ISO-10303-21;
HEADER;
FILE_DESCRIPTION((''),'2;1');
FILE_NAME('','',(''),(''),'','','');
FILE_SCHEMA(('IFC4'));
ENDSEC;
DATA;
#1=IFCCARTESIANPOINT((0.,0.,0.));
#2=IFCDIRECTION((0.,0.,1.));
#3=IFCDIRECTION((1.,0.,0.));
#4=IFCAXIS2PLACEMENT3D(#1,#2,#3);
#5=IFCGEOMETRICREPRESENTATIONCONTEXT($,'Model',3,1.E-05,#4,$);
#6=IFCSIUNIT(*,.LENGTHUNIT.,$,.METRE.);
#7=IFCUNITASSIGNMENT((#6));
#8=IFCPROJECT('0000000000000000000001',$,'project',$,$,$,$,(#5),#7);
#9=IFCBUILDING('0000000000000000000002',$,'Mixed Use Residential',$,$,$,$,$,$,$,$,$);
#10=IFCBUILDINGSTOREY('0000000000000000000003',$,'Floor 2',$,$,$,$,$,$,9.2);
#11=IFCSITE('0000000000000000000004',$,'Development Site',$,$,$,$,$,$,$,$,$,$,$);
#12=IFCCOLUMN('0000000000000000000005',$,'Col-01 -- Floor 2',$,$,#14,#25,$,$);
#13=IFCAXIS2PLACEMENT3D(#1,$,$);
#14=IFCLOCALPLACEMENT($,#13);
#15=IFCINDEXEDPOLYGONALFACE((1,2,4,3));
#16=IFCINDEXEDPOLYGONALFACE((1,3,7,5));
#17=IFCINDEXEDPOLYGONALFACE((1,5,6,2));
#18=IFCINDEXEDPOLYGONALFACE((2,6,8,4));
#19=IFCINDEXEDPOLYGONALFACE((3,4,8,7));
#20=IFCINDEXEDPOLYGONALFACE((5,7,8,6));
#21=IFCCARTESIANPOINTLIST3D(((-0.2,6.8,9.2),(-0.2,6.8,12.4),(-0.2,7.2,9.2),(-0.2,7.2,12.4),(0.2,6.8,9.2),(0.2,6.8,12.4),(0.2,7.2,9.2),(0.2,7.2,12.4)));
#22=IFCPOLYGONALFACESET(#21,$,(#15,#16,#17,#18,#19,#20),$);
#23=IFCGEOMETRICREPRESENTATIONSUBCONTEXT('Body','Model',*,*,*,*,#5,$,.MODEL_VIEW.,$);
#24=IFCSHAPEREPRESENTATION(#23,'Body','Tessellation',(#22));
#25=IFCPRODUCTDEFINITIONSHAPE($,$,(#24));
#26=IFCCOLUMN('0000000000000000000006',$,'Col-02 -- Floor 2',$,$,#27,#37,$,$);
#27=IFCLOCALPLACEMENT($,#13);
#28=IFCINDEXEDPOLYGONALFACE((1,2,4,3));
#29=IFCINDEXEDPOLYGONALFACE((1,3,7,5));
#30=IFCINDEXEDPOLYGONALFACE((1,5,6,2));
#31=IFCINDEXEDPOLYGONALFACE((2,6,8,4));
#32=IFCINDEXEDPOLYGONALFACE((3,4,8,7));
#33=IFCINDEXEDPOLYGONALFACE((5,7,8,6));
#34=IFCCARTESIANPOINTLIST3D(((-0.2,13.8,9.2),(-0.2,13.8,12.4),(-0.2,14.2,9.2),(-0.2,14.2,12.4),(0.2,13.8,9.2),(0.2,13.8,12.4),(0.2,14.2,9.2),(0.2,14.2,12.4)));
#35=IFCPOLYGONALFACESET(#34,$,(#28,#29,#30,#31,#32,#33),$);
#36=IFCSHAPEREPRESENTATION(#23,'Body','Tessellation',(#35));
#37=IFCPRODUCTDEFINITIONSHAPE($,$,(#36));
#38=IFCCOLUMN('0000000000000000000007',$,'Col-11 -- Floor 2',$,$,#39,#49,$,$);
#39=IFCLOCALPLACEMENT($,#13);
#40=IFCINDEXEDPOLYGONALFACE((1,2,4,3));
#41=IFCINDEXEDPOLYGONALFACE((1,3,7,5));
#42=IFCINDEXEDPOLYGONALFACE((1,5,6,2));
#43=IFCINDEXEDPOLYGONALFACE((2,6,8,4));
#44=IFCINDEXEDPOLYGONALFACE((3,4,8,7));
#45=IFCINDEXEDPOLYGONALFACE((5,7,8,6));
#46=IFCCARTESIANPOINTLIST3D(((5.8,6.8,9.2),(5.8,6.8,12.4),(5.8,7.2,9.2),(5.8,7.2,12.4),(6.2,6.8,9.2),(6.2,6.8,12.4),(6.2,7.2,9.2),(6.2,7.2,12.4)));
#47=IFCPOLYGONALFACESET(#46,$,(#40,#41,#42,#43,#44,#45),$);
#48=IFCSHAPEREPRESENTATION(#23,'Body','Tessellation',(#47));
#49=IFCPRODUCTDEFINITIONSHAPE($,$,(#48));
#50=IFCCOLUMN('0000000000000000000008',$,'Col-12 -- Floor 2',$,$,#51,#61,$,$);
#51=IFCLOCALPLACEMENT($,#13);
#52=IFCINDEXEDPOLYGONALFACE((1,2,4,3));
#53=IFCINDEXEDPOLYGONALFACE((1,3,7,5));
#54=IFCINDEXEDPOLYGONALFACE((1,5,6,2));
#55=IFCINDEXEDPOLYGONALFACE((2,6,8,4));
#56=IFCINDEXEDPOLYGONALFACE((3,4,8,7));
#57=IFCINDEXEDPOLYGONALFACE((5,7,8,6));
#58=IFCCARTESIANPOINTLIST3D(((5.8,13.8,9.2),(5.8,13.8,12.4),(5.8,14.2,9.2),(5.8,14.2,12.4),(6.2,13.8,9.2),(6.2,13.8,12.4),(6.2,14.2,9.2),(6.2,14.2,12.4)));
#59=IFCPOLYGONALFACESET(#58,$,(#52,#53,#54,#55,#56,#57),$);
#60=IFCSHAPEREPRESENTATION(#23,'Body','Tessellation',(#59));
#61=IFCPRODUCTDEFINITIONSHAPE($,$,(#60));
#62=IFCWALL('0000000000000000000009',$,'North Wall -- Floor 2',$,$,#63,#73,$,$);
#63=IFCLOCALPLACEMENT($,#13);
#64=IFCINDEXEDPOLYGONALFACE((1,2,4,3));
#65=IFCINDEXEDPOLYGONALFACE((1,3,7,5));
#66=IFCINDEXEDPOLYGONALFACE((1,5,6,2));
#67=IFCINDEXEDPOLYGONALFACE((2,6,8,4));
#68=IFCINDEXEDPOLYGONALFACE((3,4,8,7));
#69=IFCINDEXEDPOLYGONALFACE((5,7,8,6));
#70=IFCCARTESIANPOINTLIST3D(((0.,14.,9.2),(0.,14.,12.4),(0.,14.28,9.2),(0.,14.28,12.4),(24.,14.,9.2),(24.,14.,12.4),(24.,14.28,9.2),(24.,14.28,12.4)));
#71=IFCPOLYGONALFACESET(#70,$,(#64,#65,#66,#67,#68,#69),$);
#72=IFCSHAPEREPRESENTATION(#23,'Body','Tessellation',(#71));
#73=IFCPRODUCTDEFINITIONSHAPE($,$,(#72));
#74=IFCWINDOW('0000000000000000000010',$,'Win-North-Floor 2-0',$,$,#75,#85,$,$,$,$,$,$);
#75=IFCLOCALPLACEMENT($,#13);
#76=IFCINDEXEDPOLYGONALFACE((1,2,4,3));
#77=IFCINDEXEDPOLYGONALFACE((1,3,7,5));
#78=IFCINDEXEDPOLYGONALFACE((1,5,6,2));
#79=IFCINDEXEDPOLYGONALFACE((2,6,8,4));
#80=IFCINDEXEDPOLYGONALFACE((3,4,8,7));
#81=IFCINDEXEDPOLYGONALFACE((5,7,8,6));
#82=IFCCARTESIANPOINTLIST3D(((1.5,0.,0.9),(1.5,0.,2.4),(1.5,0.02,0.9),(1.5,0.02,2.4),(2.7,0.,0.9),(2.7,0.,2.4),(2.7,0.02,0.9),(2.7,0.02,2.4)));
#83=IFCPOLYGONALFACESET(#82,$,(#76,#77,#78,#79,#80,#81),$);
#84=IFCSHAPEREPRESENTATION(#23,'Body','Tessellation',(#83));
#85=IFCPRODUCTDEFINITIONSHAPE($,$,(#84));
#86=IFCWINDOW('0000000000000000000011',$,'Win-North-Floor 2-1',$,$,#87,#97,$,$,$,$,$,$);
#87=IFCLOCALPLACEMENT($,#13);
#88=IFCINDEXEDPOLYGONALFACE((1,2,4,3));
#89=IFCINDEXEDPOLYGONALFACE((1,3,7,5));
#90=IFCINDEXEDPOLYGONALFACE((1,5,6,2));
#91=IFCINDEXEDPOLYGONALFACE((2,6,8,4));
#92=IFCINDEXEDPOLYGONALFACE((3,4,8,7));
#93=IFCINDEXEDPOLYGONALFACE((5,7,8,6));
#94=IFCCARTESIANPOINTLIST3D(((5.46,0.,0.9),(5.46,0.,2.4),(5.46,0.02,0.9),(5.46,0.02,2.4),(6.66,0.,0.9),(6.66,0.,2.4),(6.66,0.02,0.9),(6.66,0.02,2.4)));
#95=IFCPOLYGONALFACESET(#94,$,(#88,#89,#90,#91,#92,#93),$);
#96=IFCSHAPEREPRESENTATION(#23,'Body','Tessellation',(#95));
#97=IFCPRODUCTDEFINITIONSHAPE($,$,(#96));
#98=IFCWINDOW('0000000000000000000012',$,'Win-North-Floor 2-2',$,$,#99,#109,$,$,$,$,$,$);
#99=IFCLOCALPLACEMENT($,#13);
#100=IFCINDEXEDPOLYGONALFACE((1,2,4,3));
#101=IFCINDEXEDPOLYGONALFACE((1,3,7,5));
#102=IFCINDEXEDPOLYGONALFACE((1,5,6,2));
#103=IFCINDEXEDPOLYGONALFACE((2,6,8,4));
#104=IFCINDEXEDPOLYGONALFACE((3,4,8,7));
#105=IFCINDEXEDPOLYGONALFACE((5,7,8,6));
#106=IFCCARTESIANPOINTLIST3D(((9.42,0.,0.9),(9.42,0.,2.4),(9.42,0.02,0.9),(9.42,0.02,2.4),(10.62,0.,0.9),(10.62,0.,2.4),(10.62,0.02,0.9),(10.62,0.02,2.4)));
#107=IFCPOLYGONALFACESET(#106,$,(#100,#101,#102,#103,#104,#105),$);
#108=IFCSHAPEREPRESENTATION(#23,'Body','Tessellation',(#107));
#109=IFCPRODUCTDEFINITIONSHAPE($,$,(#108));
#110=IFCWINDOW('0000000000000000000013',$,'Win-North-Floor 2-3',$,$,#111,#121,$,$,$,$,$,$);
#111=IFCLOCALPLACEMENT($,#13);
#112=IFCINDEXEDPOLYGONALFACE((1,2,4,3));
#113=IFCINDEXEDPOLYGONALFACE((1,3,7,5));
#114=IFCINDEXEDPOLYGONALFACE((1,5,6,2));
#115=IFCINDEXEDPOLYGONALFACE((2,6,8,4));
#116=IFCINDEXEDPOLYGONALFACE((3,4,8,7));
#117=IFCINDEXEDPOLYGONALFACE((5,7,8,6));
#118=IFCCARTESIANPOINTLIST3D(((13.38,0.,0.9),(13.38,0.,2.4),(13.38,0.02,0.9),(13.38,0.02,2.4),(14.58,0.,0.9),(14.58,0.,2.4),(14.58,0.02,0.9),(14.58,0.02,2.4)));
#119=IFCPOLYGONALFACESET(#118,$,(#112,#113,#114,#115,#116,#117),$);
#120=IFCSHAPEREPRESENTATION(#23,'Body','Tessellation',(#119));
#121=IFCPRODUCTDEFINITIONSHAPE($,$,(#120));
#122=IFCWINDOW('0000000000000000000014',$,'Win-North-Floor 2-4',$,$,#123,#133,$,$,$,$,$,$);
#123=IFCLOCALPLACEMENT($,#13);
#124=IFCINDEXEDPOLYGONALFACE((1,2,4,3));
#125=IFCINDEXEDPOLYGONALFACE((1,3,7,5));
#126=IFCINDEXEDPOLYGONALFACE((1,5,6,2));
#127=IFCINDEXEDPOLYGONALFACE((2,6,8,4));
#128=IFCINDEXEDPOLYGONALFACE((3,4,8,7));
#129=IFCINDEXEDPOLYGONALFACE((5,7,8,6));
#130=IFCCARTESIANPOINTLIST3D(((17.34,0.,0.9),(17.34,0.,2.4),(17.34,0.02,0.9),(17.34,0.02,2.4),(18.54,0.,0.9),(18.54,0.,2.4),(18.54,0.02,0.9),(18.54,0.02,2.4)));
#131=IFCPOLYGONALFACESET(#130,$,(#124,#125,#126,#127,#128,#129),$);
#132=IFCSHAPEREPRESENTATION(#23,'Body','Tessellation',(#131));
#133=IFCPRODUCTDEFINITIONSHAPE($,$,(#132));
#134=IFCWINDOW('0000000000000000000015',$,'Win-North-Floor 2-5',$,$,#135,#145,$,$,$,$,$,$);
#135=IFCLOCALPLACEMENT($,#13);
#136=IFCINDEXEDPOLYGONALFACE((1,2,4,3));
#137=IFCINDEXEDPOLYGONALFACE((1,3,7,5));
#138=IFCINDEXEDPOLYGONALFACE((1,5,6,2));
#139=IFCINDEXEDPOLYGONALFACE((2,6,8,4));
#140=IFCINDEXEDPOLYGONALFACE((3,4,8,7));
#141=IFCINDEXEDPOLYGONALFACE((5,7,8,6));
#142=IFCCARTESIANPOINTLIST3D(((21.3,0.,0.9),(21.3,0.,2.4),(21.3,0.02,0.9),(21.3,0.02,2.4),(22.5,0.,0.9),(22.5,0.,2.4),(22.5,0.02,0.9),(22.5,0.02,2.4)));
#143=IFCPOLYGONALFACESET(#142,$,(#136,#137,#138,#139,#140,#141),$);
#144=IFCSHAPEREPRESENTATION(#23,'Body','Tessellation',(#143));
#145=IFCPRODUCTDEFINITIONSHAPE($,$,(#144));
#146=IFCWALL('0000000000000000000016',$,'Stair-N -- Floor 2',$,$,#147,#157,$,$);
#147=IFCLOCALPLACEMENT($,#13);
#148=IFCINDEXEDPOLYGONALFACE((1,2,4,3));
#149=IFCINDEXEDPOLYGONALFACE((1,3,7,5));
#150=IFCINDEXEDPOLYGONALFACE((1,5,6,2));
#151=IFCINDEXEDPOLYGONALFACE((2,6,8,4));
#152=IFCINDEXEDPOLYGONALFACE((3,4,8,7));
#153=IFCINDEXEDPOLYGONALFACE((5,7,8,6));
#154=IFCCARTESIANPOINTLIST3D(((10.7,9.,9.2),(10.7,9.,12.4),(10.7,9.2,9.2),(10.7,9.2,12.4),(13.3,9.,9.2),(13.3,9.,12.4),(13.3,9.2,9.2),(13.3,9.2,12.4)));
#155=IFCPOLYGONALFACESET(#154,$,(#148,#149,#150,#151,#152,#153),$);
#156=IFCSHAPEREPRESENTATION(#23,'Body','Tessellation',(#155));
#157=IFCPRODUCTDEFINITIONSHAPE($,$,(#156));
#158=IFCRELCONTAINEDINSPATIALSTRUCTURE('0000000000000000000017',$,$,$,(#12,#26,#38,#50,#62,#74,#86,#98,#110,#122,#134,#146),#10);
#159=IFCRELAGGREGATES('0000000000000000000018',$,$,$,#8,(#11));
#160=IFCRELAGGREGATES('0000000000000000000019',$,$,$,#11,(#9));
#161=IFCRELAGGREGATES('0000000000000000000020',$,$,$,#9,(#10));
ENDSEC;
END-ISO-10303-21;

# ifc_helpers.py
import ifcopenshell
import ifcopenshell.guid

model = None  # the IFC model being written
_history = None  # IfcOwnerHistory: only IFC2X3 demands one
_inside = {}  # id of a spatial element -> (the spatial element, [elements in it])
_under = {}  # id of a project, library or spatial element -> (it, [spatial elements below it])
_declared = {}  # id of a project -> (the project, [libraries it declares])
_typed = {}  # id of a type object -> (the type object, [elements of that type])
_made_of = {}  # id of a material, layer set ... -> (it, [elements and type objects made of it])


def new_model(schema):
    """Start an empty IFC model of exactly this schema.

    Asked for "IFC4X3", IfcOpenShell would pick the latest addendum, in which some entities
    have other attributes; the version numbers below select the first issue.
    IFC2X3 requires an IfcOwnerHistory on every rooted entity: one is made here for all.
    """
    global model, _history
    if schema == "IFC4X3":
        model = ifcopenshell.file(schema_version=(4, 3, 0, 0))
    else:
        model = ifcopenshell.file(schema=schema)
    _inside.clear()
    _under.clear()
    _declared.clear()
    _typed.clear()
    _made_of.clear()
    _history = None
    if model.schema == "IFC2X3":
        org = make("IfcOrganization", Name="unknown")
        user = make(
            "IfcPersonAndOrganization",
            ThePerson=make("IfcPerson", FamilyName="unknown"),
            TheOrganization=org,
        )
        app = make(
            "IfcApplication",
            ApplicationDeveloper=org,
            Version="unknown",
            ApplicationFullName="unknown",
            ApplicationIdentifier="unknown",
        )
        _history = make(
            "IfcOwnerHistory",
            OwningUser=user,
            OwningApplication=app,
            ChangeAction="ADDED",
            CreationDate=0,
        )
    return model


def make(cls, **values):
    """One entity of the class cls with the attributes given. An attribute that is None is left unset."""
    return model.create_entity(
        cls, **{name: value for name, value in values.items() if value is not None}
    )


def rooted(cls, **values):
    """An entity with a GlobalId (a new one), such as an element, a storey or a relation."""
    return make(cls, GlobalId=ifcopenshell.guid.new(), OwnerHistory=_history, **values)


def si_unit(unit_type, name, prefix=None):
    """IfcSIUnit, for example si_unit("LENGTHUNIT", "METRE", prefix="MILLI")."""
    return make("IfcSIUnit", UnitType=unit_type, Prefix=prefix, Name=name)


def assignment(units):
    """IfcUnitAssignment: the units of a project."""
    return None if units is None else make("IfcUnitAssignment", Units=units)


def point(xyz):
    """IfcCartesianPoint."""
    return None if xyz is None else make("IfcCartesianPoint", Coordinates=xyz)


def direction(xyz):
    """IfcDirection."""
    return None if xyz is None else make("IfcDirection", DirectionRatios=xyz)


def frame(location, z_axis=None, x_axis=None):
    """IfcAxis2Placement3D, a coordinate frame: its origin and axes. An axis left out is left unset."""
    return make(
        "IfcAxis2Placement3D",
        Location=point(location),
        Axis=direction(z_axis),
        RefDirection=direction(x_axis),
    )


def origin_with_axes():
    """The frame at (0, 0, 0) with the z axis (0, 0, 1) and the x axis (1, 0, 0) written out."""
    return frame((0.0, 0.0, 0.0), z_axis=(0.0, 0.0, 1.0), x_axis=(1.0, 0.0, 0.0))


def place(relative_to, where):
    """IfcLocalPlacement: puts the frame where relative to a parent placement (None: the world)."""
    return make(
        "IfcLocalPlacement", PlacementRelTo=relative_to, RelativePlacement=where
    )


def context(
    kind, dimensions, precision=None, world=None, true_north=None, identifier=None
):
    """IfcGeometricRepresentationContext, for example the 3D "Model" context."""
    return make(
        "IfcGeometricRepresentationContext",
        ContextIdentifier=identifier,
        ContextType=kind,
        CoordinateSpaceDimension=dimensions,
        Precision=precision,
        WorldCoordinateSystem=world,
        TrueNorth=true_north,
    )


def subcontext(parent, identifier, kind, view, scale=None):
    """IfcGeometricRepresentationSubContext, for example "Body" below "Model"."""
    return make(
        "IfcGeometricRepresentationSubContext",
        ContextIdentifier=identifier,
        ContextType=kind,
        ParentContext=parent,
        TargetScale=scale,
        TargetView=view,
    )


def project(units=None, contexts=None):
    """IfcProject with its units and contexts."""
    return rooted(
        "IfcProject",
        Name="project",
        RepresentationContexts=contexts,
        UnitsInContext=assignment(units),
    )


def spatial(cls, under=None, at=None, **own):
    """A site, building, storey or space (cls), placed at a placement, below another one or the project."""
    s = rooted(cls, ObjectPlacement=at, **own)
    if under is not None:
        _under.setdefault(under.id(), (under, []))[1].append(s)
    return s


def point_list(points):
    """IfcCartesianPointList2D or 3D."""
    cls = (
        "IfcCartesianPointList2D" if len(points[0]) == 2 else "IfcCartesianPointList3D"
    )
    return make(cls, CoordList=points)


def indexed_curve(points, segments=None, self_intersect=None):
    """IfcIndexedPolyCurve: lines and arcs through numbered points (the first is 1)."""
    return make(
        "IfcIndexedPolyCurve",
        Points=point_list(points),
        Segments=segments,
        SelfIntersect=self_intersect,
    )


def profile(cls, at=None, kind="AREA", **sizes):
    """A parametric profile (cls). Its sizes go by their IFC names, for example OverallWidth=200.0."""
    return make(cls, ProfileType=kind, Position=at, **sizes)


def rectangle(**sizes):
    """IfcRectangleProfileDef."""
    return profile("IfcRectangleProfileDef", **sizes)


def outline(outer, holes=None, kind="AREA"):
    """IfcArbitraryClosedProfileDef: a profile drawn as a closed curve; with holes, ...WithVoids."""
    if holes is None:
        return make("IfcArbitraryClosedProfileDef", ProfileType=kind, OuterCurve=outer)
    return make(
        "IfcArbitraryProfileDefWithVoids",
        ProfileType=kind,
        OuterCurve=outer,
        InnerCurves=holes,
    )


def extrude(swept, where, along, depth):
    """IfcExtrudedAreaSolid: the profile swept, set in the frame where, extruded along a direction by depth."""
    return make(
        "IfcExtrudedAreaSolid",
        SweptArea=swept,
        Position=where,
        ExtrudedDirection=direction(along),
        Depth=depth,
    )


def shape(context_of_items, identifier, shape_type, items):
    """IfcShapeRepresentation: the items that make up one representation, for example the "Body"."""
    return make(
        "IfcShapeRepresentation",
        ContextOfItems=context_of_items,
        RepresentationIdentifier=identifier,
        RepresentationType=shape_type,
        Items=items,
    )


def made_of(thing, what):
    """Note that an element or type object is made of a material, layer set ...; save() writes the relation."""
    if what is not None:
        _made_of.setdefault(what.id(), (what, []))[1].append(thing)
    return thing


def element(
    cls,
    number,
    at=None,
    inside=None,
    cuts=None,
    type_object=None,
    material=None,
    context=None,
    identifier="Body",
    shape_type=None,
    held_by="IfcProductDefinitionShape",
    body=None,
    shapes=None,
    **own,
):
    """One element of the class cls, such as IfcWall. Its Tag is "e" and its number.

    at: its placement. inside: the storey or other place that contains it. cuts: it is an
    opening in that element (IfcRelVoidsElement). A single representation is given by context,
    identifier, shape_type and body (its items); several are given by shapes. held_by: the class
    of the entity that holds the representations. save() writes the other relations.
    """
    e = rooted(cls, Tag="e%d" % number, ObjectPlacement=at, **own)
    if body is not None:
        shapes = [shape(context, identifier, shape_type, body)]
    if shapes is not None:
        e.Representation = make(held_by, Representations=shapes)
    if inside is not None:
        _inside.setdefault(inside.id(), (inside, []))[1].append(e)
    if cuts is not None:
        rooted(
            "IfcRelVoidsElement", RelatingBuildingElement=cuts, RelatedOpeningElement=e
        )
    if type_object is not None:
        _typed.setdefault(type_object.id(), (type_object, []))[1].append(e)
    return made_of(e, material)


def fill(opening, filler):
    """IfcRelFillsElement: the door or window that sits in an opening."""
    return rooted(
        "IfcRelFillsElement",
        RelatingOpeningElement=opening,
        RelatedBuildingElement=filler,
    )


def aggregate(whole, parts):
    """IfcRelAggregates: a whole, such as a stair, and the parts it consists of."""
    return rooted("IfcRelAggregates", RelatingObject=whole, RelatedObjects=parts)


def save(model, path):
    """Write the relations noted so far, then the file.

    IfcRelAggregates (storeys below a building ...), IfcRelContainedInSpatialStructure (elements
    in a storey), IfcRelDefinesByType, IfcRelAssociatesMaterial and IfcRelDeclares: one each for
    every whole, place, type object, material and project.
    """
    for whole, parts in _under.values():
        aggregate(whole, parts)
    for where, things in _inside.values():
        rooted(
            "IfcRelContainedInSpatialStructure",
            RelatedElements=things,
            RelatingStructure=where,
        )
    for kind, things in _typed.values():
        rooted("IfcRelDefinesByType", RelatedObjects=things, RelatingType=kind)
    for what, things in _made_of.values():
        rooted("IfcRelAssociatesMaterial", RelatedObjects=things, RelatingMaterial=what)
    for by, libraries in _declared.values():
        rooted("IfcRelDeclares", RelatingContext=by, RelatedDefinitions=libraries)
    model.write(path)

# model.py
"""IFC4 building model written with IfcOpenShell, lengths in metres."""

from ifc_helpers import new_model, si_unit, frame, origin_with_axes, place, context, subcontext, project, spatial, indexed_curve, rectangle, outline, extrude, element, fill, save


model = new_model("IFC4")

# Units and contexts
model_context = context("Model", 3, precision=1e-05, world=origin_with_axes())
body_context = subcontext(model_context, "Body", "Model", "MODEL_VIEW")
ifc_project = project(units=[si_unit("LENGTHUNIT", "METRE")], contexts=[model_context])

# Site, building, storey
site = spatial("IfcSite", under=ifc_project, Name="Development Site")
building = spatial("IfcBuilding", under=site, Name="Mixed Use Residential")
storey = spatial("IfcBuildingStorey", under=building, Name="Floor 2", Elevation=9.2)

# Columns
for number, where, z_axis, x_axis, name in (
    (1, (0.0, 7.0, 9.2), (0.0, 0.0, 1.0), (1.0, 0.0, 0.0), "Col-01 -- Floor 2"),
    (2, (0.0, 14.0, 9.2), (0.0, 0.0, 1.0), (1.0, 0.0, 0.0), "Col-02 -- Floor 2"),
    (3, (6.0, 7.0, 9.2), (0.0, 0.0, 1.0), (1.0, 0.0, 0.0), "Col-11 -- Floor 2"),
    (4, (6.0, 14.0, 9.2), (0.0, 0.0, 1.0), (1.0, 0.0, 0.0), "Col-12 -- Floor 2"),
):
    element("IfcColumn", number, at=place(None, frame(where, z_axis=z_axis, x_axis=x_axis)), inside=storey, Name=name, context=body_context, shape_type="SweptSolid", body=[
        extrude(rectangle(XDim=0.4, YDim=0.4), origin_with_axes(), (0.0, 0.0, 1.0), 3.2),
    ])

# Wall, openings, windows
wall_1_placement = place(None, frame((0.0, 14.0, 9.2), z_axis=(0.0, 0.0, 1.0), x_axis=(1.0, 0.0, 0.0)))
wall_1 = element("IfcWall", 5, at=wall_1_placement, inside=storey, Name="North Wall -- Floor 2", context=body_context, shape_type="SweptSolid", body=[
    extrude(outline(indexed_curve([(0.0, 0.0), (0.0, 0.28), (24.0, 0.28), (24.0, 0.0), (0.0, 0.0)], self_intersect=False)), origin_with_axes(), (0.0, 0.0, 1.0), 3.2),
])
opening_1_placement = place(wall_1_placement, frame((1.5, -14.0, -8.3), z_axis=(0.0, 0.0, 1.0), x_axis=(1.0, 0.0, 0.0)))
opening_1 = element("IfcOpeningElement", 6, at=opening_1_placement, cuts=wall_1, context=body_context, shape_type="SweptSolid", body=[
    extrude(outline(indexed_curve([(0.0, 0.0), (0.0, 0.28), (1.2, 0.28), (1.2, 0.0), (0.0, 0.0)], self_intersect=False)), origin_with_axes(), (0.0, 0.0, 1.0), 1.5),
])
opening_2_placement = place(wall_1_placement, frame((5.46, -14.0, -8.3), z_axis=(0.0, 0.0, 1.0), x_axis=(1.0, 0.0, 0.0)))
opening_2 = element("IfcOpeningElement", 7, at=opening_2_placement, cuts=wall_1, context=body_context, shape_type="SweptSolid", body=[
    extrude(outline(indexed_curve([(0.0, 0.0), (0.0, 0.28), (1.2, 0.28), (1.2, 0.0), (0.0, 0.0)], self_intersect=False)), origin_with_axes(), (0.0, 0.0, 1.0), 1.5),
])
opening_3_placement = place(wall_1_placement, frame((9.42, -14.0, -8.3), z_axis=(0.0, 0.0, 1.0), x_axis=(1.0, 0.0, 0.0)))
opening_3 = element("IfcOpeningElement", 8, at=opening_3_placement, cuts=wall_1, context=body_context, shape_type="SweptSolid", body=[
    extrude(outline(indexed_curve([(0.0, 0.0), (0.0, 0.28), (1.2, 0.28), (1.2, 0.0), (0.0, 0.0)], self_intersect=False)), origin_with_axes(), (0.0, 0.0, 1.0), 1.5),
])
opening_4_placement = place(wall_1_placement, frame((13.38, -14.0, -8.3), z_axis=(0.0, 0.0, 1.0), x_axis=(1.0, 0.0, 0.0)))
opening_4 = element("IfcOpeningElement", 9, at=opening_4_placement, cuts=wall_1, context=body_context, shape_type="SweptSolid", body=[
    extrude(outline(indexed_curve([(0.0, 0.0), (0.0, 0.28), (1.2, 0.28), (1.2, 0.0), (0.0, 0.0)], self_intersect=False)), origin_with_axes(), (0.0, 0.0, 1.0), 1.5),
])
opening_5_placement = place(wall_1_placement, frame((17.34, -14.0, -8.3), z_axis=(0.0, 0.0, 1.0), x_axis=(1.0, 0.0, 0.0)))
opening_5 = element("IfcOpeningElement", 10, at=opening_5_placement, cuts=wall_1, context=body_context, shape_type="SweptSolid", body=[
    extrude(outline(indexed_curve([(0.0, 0.0), (0.0, 0.28), (1.2, 0.28), (1.2, 0.0), (0.0, 0.0)], self_intersect=False)), origin_with_axes(), (0.0, 0.0, 1.0), 1.5),
])
opening_6_placement = place(wall_1_placement, frame((21.3, -14.0, -8.3), z_axis=(0.0, 0.0, 1.0), x_axis=(1.0, 0.0, 0.0)))
opening_6 = element("IfcOpeningElement", 11, at=opening_6_placement, cuts=wall_1, context=body_context, shape_type="SweptSolid", body=[
    extrude(outline(indexed_curve([(0.0, 0.0), (0.0, 0.28), (1.2, 0.28), (1.2, 0.0), (0.0, 0.0)], self_intersect=False)), origin_with_axes(), (0.0, 0.0, 1.0), 1.5),
])
window_1_placement = place(None, frame((1.5, 0.0, 0.9), z_axis=(0.0, 0.0, 1.0), x_axis=(1.0, 0.0, 0.0)))
window_1 = element("IfcWindow", 12, at=window_1_placement, inside=storey, Name="Win-North-Floor 2-0", context=body_context, shape_type="SweptSolid", body=[
    extrude(outline(indexed_curve([(0.0, 0.0), (0.0, 0.02), (1.2, 0.02), (1.2, 0.0), (0.0, 0.0)], self_intersect=False)), origin_with_axes(), (0.0, 0.0, 1.0), 1.5),
])
fill(opening_1, window_1)
window_2_placement = place(None, frame((5.46, 0.0, 0.9), z_axis=(0.0, 0.0, 1.0), x_axis=(1.0, 0.0, 0.0)))
window_2 = element("IfcWindow", 13, at=window_2_placement, inside=storey, Name="Win-North-Floor 2-1", context=body_context, shape_type="SweptSolid", body=[
    extrude(outline(indexed_curve([(0.0, 0.0), (0.0, 0.02), (1.2, 0.02), (1.2, 0.0), (0.0, 0.0)], self_intersect=False)), origin_with_axes(), (0.0, 0.0, 1.0), 1.5),
])
fill(opening_2, window_2)
window_3_placement = place(None, frame((9.42, 0.0, 0.9), z_axis=(0.0, 0.0, 1.0), x_axis=(1.0, 0.0, 0.0)))
window_3 = element("IfcWindow", 14, at=window_3_placement, inside=storey, Name="Win-North-Floor 2-2", context=body_context, shape_type="SweptSolid", body=[
    extrude(outline(indexed_curve([(0.0, 0.0), (0.0, 0.02), (1.2, 0.02), (1.2, 0.0), (0.0, 0.0)], self_intersect=False)), origin_with_axes(), (0.0, 0.0, 1.0), 1.5),
])
fill(opening_3, window_3)
window_4_placement = place(None, frame((13.38, 0.0, 0.9), z_axis=(0.0, 0.0, 1.0), x_axis=(1.0, 0.0, 0.0)))
window_4 = element("IfcWindow", 15, at=window_4_placement, inside=storey, Name="Win-North-Floor 2-3", context=body_context, shape_type="SweptSolid", body=[
    extrude(outline(indexed_curve([(0.0, 0.0), (0.0, 0.02), (1.2, 0.02), (1.2, 0.0), (0.0, 0.0)], self_intersect=False)), origin_with_axes(), (0.0, 0.0, 1.0), 1.5),
])
fill(opening_4, window_4)
window_5_placement = place(None, frame((17.34, 0.0, 0.9), z_axis=(0.0, 0.0, 1.0), x_axis=(1.0, 0.0, 0.0)))
window_5 = element("IfcWindow", 16, at=window_5_placement, inside=storey, Name="Win-North-Floor 2-4", context=body_context, shape_type="SweptSolid", body=[
    extrude(outline(indexed_curve([(0.0, 0.0), (0.0, 0.02), (1.2, 0.02), (1.2, 0.0), (0.0, 0.0)], self_intersect=False)), origin_with_axes(), (0.0, 0.0, 1.0), 1.5),
])
fill(opening_5, window_5)
window_6_placement = place(None, frame((21.3, 0.0, 0.9), z_axis=(0.0, 0.0, 1.0), x_axis=(1.0, 0.0, 0.0)))
window_6 = element("IfcWindow", 17, at=window_6_placement, inside=storey, Name="Win-North-Floor 2-5", context=body_context, shape_type="SweptSolid", body=[
    extrude(outline(indexed_curve([(0.0, 0.0), (0.0, 0.02), (1.2, 0.02), (1.2, 0.0), (0.0, 0.0)], self_intersect=False)), origin_with_axes(), (0.0, 0.0, 1.0), 1.5),
])
fill(opening_6, window_6)

# Wall
wall_2_placement = place(None, frame((10.7, 9.0, 9.2), z_axis=(0.0, 0.0, 1.0), x_axis=(1.0, 0.0, 0.0)))
element("IfcWall", 18, at=wall_2_placement, inside=storey, Name="Stair-N -- Floor 2", context=body_context, shape_type="SweptSolid", body=[
    extrude(outline(indexed_curve([(0.0, 0.0), (0.0, 0.2), (2.6, 0.2), (2.6, 0.0), (0.0, 0.0)], self_intersect=False)), origin_with_axes(), (0.0, 0.0, 1.0), 3.2),
])

save(model, "model.ifc")
